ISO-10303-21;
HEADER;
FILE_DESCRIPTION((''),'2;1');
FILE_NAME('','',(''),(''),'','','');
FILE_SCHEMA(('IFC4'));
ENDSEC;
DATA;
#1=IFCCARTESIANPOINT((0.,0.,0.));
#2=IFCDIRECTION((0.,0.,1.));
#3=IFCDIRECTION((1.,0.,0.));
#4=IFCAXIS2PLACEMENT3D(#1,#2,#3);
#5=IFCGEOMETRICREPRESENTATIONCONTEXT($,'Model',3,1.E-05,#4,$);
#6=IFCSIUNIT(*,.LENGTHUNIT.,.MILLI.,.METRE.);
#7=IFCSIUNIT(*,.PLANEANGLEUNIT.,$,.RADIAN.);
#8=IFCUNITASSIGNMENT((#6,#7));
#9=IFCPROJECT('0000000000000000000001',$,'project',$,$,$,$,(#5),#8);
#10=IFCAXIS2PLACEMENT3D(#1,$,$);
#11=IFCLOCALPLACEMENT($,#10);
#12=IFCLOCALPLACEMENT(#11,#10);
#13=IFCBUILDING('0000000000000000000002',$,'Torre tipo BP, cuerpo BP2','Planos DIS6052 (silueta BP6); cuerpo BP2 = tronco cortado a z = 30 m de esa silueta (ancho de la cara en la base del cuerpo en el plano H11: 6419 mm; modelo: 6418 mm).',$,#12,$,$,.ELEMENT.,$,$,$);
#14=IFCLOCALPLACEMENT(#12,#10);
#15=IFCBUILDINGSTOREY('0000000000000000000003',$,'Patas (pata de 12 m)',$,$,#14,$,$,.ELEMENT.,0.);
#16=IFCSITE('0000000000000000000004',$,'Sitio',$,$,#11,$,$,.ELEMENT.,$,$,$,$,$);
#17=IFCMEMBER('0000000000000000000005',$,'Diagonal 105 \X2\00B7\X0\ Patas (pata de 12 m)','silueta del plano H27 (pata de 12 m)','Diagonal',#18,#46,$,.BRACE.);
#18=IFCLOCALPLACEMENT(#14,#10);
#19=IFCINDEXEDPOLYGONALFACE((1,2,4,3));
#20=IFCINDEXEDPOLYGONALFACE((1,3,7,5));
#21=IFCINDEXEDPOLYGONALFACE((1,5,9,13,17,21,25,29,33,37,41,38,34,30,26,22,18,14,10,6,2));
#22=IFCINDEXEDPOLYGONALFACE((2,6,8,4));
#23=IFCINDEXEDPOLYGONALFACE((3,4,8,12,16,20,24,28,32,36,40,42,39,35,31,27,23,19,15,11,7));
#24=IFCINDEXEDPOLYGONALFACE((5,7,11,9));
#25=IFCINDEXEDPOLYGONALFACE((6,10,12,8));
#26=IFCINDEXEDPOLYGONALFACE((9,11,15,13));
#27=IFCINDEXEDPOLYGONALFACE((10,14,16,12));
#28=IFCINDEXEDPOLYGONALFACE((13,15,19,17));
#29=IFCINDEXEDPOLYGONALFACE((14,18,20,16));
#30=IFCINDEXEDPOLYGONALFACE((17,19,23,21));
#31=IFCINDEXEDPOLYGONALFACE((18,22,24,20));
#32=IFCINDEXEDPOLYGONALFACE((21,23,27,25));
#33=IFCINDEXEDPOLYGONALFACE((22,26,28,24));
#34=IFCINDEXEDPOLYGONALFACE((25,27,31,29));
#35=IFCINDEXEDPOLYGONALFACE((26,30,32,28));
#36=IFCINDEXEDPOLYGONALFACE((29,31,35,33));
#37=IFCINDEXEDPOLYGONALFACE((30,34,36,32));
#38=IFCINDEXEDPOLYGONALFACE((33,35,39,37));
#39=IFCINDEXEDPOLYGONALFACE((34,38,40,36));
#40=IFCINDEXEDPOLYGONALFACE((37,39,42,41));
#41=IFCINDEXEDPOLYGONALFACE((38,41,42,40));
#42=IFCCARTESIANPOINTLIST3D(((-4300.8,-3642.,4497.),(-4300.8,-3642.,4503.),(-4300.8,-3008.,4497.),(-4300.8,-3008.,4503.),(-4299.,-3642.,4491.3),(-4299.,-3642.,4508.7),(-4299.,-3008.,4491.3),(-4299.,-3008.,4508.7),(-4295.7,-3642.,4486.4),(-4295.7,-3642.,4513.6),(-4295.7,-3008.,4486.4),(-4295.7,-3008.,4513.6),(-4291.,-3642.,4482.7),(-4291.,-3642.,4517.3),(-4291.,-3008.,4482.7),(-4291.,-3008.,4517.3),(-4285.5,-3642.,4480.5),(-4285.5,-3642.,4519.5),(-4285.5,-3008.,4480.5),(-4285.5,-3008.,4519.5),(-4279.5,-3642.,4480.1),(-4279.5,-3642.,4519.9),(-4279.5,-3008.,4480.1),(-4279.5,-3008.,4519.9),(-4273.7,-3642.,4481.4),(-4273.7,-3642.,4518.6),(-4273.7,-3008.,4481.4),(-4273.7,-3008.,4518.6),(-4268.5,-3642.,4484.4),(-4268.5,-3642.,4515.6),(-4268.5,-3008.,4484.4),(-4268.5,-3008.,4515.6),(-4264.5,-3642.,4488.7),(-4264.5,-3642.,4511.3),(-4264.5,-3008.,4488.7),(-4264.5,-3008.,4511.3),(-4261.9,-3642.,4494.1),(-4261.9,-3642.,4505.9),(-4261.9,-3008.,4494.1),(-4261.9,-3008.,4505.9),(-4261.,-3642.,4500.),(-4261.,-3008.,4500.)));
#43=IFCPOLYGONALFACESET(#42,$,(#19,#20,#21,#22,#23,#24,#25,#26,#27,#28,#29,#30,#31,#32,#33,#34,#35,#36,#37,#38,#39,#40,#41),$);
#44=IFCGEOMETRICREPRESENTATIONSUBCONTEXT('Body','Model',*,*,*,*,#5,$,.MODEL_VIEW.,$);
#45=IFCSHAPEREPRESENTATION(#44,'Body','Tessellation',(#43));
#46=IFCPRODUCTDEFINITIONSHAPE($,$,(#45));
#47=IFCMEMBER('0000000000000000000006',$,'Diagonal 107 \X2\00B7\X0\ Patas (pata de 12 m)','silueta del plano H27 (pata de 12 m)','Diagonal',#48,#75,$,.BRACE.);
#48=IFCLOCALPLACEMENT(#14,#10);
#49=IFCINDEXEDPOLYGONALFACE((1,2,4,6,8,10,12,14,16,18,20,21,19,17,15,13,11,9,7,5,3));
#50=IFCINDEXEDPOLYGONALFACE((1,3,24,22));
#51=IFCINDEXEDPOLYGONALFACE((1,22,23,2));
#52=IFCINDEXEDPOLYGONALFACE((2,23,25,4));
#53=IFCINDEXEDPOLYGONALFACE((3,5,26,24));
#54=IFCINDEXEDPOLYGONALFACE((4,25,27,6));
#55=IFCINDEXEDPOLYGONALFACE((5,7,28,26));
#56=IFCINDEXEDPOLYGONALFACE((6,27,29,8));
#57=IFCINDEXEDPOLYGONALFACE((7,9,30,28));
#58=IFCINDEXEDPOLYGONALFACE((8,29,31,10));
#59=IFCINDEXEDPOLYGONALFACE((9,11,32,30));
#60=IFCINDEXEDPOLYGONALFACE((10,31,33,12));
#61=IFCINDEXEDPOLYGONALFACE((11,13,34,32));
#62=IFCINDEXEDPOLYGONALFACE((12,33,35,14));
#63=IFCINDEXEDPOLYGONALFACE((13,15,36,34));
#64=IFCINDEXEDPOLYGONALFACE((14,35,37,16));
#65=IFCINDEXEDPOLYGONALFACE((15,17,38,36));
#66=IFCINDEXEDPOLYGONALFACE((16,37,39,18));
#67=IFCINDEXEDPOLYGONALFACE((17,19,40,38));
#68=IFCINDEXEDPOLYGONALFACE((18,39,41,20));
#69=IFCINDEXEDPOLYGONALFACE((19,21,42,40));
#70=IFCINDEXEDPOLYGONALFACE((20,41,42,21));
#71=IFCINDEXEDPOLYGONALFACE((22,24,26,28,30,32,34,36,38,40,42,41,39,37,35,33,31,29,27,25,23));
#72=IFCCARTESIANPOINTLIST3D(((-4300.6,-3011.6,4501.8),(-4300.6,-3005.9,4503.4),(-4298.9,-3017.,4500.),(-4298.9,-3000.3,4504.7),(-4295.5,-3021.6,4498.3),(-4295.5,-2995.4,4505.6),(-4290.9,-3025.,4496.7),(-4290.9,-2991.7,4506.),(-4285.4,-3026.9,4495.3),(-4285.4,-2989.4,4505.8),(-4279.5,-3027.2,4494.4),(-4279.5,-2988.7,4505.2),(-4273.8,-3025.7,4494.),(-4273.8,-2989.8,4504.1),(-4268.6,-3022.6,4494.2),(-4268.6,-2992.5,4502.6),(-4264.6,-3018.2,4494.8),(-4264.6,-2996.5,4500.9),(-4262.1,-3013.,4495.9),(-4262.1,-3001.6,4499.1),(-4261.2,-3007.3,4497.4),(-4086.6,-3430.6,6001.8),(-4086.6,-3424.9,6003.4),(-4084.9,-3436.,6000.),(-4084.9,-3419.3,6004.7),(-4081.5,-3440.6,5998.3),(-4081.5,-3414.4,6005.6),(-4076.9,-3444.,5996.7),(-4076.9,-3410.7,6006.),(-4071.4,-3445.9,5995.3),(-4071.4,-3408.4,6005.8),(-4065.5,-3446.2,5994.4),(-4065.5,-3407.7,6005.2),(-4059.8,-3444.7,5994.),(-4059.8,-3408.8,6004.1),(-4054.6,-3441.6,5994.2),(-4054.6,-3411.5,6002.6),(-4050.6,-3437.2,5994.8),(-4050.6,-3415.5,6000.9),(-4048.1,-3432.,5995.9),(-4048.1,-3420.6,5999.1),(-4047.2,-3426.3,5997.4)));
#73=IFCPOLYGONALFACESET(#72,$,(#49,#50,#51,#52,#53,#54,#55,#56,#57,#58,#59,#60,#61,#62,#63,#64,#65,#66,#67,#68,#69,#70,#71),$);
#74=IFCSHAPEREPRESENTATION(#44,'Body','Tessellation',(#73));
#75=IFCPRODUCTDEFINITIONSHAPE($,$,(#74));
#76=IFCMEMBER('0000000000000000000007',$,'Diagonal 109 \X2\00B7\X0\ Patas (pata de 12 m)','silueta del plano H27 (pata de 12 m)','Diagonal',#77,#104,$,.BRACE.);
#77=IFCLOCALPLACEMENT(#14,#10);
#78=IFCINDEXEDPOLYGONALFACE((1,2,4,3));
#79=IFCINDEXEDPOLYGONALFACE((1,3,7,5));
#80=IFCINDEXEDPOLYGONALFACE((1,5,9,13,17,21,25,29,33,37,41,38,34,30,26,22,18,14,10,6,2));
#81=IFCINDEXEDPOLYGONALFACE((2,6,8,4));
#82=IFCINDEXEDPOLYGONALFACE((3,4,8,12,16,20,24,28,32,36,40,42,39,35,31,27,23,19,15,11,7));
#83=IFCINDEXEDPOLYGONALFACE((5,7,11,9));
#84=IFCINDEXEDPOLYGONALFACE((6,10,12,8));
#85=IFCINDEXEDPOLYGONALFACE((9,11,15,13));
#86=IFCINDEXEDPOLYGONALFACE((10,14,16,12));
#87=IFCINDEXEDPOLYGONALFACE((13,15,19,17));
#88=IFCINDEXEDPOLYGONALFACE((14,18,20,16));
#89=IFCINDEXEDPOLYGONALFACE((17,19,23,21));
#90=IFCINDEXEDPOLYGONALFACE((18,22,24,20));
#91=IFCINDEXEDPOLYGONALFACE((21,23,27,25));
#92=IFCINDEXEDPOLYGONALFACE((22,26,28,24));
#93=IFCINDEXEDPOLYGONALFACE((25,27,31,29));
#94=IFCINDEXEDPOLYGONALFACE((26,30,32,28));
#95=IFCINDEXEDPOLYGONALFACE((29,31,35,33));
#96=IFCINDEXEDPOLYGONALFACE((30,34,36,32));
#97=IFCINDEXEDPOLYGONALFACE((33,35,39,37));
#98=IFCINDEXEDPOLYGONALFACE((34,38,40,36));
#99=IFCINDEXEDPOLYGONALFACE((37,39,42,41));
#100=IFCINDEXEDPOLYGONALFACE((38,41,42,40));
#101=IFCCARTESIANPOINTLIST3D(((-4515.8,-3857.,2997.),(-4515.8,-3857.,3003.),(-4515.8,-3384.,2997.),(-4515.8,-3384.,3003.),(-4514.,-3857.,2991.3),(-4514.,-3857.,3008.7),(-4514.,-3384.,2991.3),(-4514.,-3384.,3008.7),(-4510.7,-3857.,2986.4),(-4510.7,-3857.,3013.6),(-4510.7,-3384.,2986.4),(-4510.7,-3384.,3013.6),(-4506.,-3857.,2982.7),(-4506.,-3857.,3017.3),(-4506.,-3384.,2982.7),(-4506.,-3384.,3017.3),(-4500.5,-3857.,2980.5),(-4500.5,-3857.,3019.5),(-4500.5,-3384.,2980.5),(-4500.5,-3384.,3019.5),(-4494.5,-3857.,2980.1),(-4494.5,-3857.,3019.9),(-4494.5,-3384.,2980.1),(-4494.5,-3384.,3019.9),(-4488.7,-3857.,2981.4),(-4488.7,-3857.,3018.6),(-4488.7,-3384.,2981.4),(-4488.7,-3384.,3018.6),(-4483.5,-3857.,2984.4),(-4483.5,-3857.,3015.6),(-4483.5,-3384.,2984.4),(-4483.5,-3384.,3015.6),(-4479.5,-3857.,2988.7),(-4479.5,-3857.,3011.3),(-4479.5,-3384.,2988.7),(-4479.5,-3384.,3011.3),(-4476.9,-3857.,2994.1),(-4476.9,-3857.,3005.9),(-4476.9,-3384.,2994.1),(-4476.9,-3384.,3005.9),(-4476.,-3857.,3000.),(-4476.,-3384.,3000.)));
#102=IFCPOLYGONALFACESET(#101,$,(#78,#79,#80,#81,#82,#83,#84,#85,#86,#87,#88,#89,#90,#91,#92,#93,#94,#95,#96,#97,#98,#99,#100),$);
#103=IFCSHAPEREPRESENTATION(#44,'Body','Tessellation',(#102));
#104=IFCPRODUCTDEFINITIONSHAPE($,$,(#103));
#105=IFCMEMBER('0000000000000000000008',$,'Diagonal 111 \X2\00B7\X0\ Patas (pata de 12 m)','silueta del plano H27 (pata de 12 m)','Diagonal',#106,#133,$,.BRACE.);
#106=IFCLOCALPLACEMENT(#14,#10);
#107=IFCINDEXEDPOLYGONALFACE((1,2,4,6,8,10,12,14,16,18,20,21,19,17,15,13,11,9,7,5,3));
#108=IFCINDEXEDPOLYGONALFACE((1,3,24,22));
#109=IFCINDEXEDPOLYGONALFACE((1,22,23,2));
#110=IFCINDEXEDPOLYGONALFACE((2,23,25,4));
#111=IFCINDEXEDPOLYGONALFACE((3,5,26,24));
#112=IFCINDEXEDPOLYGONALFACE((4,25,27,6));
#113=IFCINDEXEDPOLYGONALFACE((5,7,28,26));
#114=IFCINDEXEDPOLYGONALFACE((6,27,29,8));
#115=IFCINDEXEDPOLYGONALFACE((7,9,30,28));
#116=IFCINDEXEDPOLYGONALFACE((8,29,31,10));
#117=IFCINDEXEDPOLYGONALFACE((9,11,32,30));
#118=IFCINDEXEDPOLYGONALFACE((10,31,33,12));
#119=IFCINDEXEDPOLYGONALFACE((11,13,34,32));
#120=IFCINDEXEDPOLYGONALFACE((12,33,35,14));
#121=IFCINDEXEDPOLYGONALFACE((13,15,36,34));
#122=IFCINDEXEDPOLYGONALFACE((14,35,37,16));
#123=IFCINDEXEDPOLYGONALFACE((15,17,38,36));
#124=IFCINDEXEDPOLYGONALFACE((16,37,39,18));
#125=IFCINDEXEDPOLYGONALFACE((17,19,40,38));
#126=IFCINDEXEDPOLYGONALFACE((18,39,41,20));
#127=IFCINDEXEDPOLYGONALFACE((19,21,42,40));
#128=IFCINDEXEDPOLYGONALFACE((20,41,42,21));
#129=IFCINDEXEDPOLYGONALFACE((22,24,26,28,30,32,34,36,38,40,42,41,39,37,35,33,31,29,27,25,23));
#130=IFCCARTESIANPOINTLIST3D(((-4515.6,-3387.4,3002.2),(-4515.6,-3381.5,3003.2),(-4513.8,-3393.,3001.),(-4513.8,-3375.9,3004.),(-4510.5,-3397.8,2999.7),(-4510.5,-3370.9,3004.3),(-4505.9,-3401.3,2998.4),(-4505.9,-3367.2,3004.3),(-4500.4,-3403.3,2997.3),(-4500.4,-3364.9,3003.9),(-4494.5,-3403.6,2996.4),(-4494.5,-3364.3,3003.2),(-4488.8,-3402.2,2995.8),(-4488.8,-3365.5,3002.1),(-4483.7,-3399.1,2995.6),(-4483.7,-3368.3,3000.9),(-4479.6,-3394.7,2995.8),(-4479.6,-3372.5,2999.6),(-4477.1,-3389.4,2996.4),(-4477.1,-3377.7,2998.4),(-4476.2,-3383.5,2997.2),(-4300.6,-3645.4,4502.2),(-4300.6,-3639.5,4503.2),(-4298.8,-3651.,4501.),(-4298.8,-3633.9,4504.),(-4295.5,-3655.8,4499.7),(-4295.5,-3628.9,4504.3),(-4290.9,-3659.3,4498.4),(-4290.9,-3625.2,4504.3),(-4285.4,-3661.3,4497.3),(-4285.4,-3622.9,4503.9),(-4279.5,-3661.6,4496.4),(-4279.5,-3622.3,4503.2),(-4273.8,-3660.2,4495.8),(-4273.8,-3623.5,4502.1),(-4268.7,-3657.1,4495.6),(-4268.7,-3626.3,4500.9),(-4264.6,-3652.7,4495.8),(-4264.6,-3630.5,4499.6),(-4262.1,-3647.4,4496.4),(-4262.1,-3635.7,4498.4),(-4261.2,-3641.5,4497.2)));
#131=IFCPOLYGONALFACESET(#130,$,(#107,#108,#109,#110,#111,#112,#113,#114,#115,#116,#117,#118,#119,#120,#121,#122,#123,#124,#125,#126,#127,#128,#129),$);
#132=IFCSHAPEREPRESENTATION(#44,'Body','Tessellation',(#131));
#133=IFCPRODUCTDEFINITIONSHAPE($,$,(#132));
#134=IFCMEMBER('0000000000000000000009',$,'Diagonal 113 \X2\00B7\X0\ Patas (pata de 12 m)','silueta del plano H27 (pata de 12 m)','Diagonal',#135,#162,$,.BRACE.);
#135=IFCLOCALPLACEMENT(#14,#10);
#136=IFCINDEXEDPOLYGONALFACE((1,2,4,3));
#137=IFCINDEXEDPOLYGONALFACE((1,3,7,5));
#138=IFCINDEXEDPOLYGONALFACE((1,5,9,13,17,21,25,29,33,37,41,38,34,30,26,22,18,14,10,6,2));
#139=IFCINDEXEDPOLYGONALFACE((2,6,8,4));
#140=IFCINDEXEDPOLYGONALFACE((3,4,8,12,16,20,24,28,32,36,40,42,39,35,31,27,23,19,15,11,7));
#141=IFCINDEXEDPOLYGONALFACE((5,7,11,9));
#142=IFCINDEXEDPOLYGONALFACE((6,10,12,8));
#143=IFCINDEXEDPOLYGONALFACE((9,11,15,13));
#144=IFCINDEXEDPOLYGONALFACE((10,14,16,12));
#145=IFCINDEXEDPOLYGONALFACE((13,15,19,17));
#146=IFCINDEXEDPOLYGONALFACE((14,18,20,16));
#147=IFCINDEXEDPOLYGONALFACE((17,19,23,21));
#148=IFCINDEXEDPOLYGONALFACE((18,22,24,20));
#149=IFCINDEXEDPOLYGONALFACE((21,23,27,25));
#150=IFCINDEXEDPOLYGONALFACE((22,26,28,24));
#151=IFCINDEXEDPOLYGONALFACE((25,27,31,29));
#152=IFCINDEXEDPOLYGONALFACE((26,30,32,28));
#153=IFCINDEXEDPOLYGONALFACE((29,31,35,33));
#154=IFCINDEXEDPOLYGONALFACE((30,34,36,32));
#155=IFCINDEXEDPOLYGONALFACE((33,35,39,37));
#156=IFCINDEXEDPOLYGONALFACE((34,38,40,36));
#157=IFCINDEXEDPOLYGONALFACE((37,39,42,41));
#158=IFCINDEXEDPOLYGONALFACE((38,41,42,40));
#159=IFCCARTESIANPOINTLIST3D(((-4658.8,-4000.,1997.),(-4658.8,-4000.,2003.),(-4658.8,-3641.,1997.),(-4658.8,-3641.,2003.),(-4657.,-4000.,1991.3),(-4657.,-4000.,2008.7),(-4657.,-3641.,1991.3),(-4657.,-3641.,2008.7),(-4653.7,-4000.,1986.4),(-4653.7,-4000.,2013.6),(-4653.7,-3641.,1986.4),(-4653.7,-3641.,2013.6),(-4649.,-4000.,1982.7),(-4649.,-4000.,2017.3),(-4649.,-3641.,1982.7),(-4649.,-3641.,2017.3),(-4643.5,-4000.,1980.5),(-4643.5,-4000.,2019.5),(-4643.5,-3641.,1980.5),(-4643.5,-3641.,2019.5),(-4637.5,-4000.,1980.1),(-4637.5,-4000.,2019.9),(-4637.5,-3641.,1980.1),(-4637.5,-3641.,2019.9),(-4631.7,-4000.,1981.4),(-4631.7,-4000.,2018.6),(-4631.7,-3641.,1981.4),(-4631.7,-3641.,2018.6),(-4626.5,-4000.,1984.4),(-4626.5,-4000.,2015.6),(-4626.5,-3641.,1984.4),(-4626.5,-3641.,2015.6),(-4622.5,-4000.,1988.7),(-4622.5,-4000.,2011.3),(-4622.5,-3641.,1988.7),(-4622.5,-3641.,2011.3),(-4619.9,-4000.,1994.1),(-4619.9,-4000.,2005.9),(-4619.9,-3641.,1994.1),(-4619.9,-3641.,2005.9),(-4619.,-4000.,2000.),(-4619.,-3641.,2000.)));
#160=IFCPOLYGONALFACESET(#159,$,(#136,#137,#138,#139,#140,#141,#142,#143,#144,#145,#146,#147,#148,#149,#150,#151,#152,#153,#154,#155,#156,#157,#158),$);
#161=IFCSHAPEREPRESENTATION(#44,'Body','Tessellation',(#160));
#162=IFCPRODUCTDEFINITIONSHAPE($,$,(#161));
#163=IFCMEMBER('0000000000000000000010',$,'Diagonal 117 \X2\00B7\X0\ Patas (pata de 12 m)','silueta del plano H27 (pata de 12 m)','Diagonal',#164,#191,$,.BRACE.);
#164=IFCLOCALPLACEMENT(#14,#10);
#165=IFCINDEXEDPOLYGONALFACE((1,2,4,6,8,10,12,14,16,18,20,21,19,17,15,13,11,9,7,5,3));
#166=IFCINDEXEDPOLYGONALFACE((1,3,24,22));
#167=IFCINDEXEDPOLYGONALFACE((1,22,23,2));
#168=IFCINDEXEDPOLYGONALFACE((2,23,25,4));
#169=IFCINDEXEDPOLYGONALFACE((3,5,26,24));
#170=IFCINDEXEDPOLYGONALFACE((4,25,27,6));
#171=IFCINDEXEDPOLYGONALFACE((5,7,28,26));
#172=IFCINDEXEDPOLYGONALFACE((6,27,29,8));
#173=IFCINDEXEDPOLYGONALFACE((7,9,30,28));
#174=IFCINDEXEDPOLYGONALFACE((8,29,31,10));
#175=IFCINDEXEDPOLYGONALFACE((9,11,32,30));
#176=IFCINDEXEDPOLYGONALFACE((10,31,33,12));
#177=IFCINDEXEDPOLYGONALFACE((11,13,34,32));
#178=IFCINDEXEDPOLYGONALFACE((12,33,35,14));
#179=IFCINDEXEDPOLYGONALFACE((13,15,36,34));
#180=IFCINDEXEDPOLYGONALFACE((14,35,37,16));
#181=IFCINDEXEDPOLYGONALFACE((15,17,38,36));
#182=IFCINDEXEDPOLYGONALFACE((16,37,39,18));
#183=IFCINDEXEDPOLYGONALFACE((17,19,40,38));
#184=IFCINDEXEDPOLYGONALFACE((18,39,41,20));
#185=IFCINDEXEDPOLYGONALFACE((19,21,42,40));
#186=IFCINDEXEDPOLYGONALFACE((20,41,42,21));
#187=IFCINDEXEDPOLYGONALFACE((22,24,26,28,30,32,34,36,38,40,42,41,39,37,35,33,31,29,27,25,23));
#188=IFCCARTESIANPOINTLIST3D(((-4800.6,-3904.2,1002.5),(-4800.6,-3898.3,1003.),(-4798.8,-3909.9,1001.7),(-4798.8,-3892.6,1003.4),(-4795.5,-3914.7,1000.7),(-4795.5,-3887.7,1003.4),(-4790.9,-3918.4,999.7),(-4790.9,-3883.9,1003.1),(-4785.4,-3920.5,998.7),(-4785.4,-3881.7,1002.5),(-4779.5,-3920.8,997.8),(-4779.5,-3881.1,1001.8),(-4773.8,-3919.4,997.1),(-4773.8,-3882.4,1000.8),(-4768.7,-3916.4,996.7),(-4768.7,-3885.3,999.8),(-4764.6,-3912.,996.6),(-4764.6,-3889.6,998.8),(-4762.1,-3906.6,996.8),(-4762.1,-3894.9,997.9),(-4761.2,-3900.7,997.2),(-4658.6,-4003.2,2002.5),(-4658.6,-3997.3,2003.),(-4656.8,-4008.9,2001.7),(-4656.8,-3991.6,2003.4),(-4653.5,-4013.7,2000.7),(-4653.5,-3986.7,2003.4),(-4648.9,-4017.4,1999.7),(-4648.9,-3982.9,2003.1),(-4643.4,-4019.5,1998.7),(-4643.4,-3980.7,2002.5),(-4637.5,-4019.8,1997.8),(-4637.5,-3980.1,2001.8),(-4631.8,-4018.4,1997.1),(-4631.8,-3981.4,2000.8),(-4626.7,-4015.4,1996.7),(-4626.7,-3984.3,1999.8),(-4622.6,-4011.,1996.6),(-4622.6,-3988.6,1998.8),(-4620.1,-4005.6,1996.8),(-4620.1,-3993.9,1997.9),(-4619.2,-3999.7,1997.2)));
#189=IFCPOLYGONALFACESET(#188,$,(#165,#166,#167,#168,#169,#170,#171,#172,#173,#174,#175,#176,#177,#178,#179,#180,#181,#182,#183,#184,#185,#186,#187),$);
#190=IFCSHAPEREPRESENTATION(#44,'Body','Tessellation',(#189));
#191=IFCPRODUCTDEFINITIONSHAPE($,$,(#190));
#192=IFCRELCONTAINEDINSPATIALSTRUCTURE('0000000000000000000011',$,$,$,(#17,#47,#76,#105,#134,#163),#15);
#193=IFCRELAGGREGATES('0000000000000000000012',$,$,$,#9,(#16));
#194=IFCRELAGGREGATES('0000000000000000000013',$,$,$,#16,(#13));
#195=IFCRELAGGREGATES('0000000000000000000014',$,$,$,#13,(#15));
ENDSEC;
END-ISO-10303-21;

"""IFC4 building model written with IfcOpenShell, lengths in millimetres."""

from ifc_helpers import new_model, si_unit, frame, origin, origin_with_axes, place, context, subcontext, project, spatial, circle, extrude, element, save


model = new_model("IFC4")

# Units and contexts
model_context = context("Model", 3, precision=1e-05, world=origin_with_axes())
body_context = subcontext(model_context, "Body", "Model", "MODEL_VIEW")
ifc_project = project(units=[si_unit("LENGTHUNIT", "METRE", prefix="MILLI"), si_unit("PLANEANGLEUNIT", "RADIAN")], contexts=[model_context])

# Site, building, storey
site_placement = place(None, origin())
site = spatial("IfcSite", under=ifc_project, at=site_placement, Name="Sitio", CompositionType="ELEMENT")
building_placement = place(site_placement, origin())
building = spatial("IfcBuilding", under=site, at=building_placement, Name="Torre tipo BP, cuerpo BP2", Description="Planos DIS6052 (silueta BP6); cuerpo BP2 = tronco cortado a z = 30 m de esa silueta (ancho de la cara en la base del cuerpo en el plano H11: 6419 mm; modelo: 6418 mm).", CompositionType="ELEMENT")
storey_placement = place(building_placement, origin())
storey = spatial("IfcBuildingStorey", under=building, at=storey_placement, Name="Patas (pata de 12 m)", CompositionType="ELEMENT", Elevation=0.0)

# Members
member_1_placement = place(storey_placement, frame((-4281.0, -3642.0, 4500.0), z_axis=(0.0, 1.0, 0.0), x_axis=(1.0, 0.0, 0.0)))
element("IfcMember", 1, at=member_1_placement, inside=storey, Name="Diagonal 105 · Patas (pata de 12 m)", Description="silueta del plano H27 (pata de 12 m)", ObjectType="Diagonal", PredefinedType="BRACE", context=body_context, shape_type="SweptSolid", body=[
    extrude(circle(Radius=20.0), None, (0.0, 0.0, 1.0), 634.0),
])
member_2_placement = place(storey_placement, frame((-4281.0, -3008.0, 4500.0), z_axis=(0.136128, -0.26653, 0.954165), x_axis=(0.990691, 0.036623, -0.131109)))
element("IfcMember", 2, at=member_2_placement, inside=storey, Name="Diagonal 107 · Patas (pata de 12 m)", Description="silueta del plano H27 (pata de 12 m)", ObjectType="Diagonal", PredefinedType="BRACE", context=body_context, shape_type="SweptSolid", body=[
    extrude(circle(Radius=20.0), None, (0.0, 0.0, 1.0), 1572.1),
])
member_3_placement = place(storey_placement, frame((-4496.0, -3857.0, 3000.0), z_axis=(0.0, 1.0, 0.0), x_axis=(1.0, 0.0, 0.0)))
element("IfcMember", 3, at=member_3_placement, inside=storey, Name="Diagonal 109 · Patas (pata de 12 m)", Description="silueta del plano H27 (pata de 12 m)", ObjectType="Diagonal", PredefinedType="BRACE", context=body_context, shape_type="SweptSolid", body=[
    extrude(circle(Radius=20.0), None, (0.0, 0.0, 1.0), 473.0),
])
member_4_placement = place(storey_placement, frame((-4496.0, -3384.0, 3000.0), z_axis=(0.13987, -0.167845, 0.97584), x_axis=(0.99017, 0.02371, -0.137846)))
element("IfcMember", 4, at=member_4_placement, inside=storey, Name="Diagonal 111 · Patas (pata de 12 m)", Description="silueta del plano H27 (pata de 12 m)", ObjectType="Diagonal", PredefinedType="BRACE", context=body_context, shape_type="SweptSolid", body=[
    extrude(circle(Radius=20.0), None, (0.0, 0.0, 1.0), 1537.1),
])
member_5_placement = place(storey_placement, frame((-4639.0, -4000.0, 2000.0), z_axis=(0.0, 1.0, 0.0), x_axis=(1.0, 0.0, 0.0)))
element("IfcMember", 5, at=member_5_placement, inside=storey, Name="Diagonal 113 · Patas (pata de 12 m)", Description="silueta del plano H27 (pata de 12 m)", ObjectType="Diagonal", PredefinedType="BRACE", context=body_context, shape_type="SweptSolid", body=[
    extrude(circle(Radius=20.0), None, (0.0, 0.0, 1.0), 359.0),
])
member_6_placement = place(storey_placement, frame((-4781.0, -3901.0, 1000.0), z_axis=(0.139919, -0.097549, 0.985346), x_axis=(0.990163, 0.013785, -0.139238)))
element("IfcMember", 6, at=member_6_placement, inside=storey, Name="Diagonal 117 · Patas (pata de 12 m)", Description="silueta del plano H27 (pata de 12 m)", ObjectType="Diagonal", PredefinedType="BRACE", context=body_context, shape_type="SweptSolid", body=[
    extrude(circle(Radius=20.0), None, (0.0, 0.0, 1.0), 1014.9),
])

save(model, "model.ifc")
